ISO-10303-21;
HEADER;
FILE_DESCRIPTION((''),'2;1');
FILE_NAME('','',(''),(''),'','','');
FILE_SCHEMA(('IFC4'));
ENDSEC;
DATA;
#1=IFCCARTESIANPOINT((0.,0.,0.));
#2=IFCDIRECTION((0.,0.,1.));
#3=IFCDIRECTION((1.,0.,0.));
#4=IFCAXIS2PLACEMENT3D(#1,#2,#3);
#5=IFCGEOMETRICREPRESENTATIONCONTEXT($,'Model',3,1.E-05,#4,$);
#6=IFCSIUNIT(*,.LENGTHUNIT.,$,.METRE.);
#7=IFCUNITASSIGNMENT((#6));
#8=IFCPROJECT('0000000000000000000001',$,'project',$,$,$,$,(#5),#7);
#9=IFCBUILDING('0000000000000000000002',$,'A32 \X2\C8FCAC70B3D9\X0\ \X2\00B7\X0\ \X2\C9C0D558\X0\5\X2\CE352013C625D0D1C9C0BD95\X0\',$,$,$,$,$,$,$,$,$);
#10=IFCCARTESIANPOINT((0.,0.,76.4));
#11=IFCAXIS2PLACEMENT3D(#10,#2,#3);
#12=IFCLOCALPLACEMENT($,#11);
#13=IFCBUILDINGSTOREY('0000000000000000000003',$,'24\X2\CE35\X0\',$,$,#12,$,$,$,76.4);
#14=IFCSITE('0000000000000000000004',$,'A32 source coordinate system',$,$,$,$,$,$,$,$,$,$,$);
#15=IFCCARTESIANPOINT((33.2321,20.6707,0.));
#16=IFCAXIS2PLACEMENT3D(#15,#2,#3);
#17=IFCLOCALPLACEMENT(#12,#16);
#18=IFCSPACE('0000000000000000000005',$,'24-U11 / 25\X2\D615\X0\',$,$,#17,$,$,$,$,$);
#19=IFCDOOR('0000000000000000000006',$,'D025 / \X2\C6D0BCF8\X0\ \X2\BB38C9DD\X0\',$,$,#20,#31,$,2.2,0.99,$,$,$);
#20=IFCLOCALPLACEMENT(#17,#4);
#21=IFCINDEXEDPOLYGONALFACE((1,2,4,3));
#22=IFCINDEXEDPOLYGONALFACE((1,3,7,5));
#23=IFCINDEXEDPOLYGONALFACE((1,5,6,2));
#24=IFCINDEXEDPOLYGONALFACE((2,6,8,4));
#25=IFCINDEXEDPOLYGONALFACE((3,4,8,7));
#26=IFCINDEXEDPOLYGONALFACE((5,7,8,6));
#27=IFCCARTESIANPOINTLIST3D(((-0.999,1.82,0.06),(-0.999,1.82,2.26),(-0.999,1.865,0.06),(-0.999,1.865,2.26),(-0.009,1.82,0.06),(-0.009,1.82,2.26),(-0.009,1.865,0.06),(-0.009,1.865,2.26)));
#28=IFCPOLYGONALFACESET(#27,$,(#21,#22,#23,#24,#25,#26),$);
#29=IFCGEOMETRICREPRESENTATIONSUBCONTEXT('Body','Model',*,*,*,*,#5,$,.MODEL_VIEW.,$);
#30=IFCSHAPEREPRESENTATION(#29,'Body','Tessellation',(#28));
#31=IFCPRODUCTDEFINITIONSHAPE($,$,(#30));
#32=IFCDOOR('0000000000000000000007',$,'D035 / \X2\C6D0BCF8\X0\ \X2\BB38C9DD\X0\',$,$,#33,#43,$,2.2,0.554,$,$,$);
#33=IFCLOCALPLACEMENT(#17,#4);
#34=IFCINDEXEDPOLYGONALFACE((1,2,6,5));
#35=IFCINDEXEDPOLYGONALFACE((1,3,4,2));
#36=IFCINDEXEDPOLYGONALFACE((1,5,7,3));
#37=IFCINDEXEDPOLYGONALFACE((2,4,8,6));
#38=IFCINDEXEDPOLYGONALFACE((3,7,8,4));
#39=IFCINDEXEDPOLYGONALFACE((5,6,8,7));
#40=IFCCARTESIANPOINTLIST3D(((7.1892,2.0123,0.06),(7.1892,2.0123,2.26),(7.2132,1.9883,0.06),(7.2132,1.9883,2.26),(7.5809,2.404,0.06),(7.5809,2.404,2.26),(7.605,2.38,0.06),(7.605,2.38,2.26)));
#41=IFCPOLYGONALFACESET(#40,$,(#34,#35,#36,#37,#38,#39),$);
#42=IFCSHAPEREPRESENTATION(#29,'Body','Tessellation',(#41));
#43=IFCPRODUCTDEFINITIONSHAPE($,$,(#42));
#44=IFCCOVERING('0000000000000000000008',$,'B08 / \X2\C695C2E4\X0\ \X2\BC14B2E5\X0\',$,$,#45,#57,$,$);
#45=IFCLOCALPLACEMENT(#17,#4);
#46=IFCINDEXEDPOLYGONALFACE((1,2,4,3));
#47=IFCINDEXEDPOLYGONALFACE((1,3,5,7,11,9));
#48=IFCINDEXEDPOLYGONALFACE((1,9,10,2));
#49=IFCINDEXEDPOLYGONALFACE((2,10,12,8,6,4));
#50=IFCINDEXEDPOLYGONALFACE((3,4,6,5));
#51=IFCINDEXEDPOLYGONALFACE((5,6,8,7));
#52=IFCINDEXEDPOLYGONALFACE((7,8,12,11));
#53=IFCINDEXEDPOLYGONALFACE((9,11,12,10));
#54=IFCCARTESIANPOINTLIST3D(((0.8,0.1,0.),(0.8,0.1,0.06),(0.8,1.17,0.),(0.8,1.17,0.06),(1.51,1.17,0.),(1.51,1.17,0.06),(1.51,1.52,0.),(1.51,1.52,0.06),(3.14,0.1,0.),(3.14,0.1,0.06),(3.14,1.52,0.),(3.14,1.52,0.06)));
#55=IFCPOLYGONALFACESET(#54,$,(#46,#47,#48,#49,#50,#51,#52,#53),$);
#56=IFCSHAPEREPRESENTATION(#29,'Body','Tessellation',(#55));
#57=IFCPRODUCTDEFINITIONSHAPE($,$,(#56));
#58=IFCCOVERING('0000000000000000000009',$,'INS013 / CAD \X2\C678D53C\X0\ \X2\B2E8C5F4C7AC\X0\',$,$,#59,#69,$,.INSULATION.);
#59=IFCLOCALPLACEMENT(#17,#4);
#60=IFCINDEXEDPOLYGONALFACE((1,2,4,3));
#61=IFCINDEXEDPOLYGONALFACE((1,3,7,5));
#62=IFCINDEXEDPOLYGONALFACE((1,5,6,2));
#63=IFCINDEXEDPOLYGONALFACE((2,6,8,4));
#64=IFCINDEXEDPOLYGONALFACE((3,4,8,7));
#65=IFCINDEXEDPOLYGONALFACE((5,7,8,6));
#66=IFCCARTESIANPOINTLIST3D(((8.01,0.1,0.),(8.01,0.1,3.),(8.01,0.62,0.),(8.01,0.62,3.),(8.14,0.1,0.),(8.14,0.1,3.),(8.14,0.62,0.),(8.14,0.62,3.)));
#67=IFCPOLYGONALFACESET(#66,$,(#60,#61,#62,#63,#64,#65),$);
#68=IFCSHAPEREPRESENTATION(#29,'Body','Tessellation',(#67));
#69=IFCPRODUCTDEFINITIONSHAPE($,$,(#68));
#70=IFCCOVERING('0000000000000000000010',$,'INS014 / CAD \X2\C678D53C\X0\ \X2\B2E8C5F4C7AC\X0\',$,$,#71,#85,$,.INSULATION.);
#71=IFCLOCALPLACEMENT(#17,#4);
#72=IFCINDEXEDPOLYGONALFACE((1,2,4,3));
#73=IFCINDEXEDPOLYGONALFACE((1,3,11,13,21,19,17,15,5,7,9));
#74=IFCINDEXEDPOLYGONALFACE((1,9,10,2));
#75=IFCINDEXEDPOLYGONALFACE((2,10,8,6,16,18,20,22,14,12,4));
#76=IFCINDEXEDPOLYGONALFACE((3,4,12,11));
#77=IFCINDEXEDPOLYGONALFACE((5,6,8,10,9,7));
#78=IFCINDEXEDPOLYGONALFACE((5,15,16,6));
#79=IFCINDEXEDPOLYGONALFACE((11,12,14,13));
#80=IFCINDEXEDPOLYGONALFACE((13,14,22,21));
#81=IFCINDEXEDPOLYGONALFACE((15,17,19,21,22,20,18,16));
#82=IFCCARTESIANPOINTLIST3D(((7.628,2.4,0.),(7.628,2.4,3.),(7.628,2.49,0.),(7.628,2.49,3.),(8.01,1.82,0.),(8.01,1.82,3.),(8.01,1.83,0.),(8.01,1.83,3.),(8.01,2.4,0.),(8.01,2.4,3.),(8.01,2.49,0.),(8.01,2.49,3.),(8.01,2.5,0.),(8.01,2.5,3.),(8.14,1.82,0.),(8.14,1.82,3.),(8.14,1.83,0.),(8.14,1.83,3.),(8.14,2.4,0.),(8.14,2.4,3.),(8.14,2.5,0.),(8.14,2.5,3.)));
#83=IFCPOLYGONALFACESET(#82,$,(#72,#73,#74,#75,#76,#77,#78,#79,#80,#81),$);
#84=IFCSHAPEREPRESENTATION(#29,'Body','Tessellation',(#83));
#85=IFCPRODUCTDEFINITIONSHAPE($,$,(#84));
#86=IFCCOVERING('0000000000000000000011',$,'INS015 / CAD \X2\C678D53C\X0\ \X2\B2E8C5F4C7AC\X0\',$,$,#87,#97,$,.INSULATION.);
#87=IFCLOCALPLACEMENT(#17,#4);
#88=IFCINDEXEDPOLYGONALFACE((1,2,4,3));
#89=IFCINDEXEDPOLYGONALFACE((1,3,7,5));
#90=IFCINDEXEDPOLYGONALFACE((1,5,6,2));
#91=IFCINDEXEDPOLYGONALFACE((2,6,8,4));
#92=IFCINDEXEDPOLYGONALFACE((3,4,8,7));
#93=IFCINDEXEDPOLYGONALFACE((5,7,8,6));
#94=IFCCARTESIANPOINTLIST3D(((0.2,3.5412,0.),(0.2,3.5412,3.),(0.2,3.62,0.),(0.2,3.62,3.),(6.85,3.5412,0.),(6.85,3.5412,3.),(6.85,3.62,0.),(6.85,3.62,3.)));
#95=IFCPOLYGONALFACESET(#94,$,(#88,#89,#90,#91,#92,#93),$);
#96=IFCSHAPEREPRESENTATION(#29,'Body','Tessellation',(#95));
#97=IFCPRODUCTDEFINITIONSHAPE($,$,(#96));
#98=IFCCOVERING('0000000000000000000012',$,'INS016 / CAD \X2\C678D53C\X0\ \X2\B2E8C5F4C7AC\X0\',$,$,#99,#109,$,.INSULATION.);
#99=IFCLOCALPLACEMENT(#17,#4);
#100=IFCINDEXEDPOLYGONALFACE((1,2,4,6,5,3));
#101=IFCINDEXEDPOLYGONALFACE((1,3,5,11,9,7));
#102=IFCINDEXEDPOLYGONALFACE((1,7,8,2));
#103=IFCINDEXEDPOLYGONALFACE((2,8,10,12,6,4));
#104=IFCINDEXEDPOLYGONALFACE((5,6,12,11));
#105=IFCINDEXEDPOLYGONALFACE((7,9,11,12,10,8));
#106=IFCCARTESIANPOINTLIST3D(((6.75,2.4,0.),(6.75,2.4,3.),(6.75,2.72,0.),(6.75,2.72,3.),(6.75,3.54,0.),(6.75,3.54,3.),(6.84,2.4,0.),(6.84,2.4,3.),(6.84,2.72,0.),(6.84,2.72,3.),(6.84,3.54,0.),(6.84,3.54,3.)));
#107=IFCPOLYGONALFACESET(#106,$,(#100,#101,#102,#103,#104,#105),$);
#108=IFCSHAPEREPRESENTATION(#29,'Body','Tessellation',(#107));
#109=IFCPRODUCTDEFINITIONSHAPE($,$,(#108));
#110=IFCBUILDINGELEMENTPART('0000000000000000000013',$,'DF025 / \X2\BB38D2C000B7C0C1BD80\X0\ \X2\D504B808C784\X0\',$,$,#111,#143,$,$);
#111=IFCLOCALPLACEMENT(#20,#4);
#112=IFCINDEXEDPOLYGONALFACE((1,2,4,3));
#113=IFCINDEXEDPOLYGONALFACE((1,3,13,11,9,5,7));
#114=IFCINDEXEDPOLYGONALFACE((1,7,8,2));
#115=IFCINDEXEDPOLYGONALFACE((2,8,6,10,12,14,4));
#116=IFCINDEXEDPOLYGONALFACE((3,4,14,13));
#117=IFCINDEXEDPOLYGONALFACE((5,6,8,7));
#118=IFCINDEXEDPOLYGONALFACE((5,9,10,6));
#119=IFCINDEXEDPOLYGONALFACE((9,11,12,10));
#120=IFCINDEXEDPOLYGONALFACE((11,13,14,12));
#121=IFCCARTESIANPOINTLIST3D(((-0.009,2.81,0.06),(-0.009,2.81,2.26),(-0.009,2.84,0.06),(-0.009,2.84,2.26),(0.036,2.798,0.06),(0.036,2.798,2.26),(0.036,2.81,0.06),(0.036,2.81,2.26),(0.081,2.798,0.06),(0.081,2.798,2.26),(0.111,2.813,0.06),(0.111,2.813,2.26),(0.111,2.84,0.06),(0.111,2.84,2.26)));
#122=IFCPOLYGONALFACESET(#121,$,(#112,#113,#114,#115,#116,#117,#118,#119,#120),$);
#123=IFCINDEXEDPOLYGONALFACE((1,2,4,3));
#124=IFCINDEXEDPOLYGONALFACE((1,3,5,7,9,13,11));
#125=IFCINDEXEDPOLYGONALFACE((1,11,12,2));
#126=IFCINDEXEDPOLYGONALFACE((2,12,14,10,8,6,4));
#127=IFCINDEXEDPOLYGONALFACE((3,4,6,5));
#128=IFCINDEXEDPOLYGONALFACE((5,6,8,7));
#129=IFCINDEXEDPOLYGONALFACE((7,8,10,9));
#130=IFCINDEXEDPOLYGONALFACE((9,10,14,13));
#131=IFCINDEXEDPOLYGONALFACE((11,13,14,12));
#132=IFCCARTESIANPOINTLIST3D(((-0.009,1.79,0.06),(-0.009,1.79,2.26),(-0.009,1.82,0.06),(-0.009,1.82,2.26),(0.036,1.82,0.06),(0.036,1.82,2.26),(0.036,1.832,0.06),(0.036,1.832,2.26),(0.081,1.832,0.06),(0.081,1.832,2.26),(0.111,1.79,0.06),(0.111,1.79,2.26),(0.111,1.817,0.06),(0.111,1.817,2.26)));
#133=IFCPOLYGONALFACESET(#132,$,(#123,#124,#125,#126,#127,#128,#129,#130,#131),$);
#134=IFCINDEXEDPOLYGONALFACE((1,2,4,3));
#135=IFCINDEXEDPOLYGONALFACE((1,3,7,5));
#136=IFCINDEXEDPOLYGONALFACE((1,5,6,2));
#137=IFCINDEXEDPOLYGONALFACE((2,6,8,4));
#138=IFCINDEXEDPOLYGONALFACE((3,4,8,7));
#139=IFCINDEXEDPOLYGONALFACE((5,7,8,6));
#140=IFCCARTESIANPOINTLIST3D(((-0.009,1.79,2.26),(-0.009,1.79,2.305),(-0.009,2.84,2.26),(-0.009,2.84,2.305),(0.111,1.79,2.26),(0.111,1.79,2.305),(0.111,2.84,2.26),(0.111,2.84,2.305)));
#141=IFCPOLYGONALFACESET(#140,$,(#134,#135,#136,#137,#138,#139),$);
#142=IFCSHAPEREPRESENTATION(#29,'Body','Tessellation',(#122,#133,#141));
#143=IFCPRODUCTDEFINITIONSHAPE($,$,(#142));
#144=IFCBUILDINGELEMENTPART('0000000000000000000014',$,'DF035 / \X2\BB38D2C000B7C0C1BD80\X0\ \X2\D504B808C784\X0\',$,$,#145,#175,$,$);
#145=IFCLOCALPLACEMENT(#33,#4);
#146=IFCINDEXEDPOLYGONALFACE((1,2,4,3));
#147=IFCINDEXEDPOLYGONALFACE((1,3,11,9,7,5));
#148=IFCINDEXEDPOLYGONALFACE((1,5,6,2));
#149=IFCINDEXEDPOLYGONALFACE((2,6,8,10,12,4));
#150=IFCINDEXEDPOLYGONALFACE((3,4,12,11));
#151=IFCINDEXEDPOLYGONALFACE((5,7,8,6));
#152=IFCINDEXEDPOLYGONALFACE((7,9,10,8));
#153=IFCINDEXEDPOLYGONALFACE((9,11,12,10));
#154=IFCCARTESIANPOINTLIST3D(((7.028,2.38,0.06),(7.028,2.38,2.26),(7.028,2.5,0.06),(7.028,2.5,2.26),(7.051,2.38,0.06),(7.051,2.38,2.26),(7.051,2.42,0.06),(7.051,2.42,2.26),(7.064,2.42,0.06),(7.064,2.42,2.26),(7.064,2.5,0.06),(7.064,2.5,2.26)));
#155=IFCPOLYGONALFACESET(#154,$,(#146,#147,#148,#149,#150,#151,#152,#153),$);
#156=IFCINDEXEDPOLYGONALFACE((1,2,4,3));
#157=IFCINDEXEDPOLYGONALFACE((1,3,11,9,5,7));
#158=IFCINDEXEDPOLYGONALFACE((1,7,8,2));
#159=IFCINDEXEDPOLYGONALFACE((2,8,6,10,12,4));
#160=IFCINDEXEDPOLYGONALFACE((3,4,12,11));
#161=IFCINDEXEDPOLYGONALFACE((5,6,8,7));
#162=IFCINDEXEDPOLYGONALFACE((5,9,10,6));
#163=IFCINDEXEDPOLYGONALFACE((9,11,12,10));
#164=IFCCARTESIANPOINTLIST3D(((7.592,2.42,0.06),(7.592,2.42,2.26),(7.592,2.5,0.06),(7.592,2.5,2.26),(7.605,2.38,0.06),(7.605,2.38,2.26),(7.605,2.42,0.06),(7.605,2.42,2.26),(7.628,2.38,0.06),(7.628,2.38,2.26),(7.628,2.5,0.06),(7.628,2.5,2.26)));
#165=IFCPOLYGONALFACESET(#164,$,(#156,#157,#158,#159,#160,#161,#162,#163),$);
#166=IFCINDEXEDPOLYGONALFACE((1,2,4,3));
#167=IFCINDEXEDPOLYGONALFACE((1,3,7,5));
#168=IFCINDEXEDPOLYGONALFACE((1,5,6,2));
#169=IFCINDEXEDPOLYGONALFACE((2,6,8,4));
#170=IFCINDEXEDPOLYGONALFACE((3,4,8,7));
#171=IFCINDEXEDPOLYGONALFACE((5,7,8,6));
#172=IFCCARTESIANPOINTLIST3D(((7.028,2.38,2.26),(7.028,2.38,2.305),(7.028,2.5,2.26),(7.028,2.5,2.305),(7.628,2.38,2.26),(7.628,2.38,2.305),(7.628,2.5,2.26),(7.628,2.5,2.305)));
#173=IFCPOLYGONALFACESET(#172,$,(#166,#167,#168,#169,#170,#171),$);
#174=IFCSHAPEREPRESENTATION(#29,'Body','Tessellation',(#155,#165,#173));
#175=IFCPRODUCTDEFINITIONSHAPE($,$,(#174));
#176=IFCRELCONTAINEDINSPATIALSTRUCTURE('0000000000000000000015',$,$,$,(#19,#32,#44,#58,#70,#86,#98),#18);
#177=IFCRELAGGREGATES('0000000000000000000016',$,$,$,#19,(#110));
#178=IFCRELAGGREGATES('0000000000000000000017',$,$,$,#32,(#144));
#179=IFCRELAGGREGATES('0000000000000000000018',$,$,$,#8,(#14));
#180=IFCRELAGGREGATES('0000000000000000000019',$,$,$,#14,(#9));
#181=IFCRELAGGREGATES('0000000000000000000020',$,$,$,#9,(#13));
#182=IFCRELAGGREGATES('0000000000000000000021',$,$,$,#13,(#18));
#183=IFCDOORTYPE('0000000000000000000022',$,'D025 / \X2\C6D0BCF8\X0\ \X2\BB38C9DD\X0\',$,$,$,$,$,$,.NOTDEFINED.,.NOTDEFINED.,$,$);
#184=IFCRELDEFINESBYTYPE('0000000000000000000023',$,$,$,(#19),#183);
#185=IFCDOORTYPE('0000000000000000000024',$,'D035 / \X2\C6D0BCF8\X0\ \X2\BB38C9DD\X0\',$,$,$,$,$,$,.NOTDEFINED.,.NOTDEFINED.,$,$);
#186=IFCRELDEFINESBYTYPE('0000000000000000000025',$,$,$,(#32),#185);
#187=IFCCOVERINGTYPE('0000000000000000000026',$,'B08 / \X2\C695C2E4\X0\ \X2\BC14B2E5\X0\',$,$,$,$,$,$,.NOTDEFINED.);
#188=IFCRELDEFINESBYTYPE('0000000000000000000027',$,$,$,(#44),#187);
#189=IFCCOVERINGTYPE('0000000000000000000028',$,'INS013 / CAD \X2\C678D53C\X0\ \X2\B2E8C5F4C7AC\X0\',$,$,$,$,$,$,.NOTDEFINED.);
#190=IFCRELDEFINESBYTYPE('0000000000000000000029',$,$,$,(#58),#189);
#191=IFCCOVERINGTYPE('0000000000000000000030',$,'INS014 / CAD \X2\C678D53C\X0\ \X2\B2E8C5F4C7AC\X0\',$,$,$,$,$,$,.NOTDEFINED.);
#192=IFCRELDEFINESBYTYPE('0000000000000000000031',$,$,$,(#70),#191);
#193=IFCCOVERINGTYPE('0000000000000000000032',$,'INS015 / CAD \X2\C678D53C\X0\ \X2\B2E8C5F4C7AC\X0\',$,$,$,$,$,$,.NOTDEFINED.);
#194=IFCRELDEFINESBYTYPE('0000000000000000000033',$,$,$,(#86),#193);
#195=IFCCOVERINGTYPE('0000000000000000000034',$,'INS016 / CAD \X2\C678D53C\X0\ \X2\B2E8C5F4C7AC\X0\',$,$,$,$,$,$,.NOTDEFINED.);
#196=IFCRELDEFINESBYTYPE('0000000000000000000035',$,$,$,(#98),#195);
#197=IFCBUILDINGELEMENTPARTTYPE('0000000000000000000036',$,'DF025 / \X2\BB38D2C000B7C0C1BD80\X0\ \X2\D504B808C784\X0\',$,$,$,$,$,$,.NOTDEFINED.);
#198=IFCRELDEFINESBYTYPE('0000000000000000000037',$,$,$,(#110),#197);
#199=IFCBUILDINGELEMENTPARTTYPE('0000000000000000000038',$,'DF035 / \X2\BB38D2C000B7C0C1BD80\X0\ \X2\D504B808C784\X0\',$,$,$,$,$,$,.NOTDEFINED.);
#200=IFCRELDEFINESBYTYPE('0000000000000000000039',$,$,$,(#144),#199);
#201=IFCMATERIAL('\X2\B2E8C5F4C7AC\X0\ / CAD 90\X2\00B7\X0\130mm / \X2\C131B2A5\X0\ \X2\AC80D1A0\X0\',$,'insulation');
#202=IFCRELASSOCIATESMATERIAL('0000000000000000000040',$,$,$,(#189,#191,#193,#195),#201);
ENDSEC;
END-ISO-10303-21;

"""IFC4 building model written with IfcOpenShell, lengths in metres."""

from ifc_helpers import new_model, si_unit, frame, origin, origin_with_axes, place, context, subcontext, project, spatial, polyline, outline, extrude, source, transform, mapped, material, type_object, type_shapes, element, aggregate, save


model = new_model("IFC4")

# Units and contexts
model_context = context("Model", 3, precision=1e-05, world=origin_with_axes())
body_context = subcontext(model_context, "Body", "Model", "MODEL_VIEW")
ifc_project = project(units=[si_unit("LENGTHUNIT", "METRE")], contexts=[model_context])

# Site, building, storey, space
storey_placement = place(None, frame((0.0, 0.0, 76.4), z_axis=(0.0, 0.0, 1.0), x_axis=(1.0, 0.0, 0.0)))
space_1_placement = place(storey_placement, frame((33.2321, 20.6707, 0.0), z_axis=(0.0, 0.0, 1.0), x_axis=(1.0, 0.0, 0.0)))
site = spatial("IfcSite", under=ifc_project, Name="A32 source coordinate system")
building = spatial("IfcBuilding", under=site, Name="A32 주거동 · 지하5층–옥탑지붕")
storey = spatial("IfcBuildingStorey", under=building, at=storey_placement, Name="24층", Elevation=76.4)
space_1 = spatial("IfcSpace", under=storey, at=space_1_placement, Name="24-U11 / 25형")

# Doors
door_type_1 = type_object("IfcDoorType", Name="D025 / 원본 문짝", OperationType="NOTDEFINED", PredefinedType="NOTDEFINED")
shared_shape_1 = source(origin(), body_context, "Body", "SweptSolid", [
    extrude(outline(polyline([(-0.009, 1.82), (-0.999, 1.82), (-0.999, 1.865), (-0.009, 1.865), (-0.009, 1.82)])), frame((0.0, 0.0, 0.06)), (0.0, 0.0, 1.0), 2.2),
])
type_shapes(door_type_1, [shared_shape_1])
door_1_placement = place(space_1_placement, origin_with_axes())
door_1 = element("IfcDoor", 1, at=door_1_placement, inside=space_1, type_object=door_type_1, Name="D025 / 원본 문짝", OverallHeight=2.2, OverallWidth=0.99, context=body_context, shape_type="MappedRepresentation", body=[
    mapped(shared_shape_1, transform((0.0, 0.0, 0.0), scale=1.0)),
])
door_type_2 = type_object("IfcDoorType", Name="D035 / 원본 문짝", OperationType="NOTDEFINED", PredefinedType="NOTDEFINED")
shared_shape_2 = source(origin(), body_context, "Body", "SweptSolid", [
    extrude(outline(polyline([(7.605, 2.38), (7.2132, 1.9883), (7.1892, 2.0123), (7.5809, 2.404), (7.605, 2.38)])), frame((0.0, 0.0, 0.06)), (0.0, 0.0, 1.0), 2.2),
])
type_shapes(door_type_2, [shared_shape_2])
door_2_placement = place(space_1_placement, origin_with_axes())
door_2 = element("IfcDoor", 2, at=door_2_placement, inside=space_1, type_object=door_type_2, Name="D035 / 원본 문짝", OverallHeight=2.2, OverallWidth=0.554, context=body_context, shape_type="MappedRepresentation", body=[
    mapped(shared_shape_2, transform((0.0, 0.0, 0.0), scale=1.0)),
])

# Coverings
covering_type_1 = type_object("IfcCoveringType", Name="B08 / 욕실 바닥", PredefinedType="NOTDEFINED")
shared_shape_3 = source(origin(), body_context, "Body", "SweptSolid", [
    extrude(outline(polyline([(3.14, 0.1), (0.8, 0.1), (0.8, 1.17), (1.51, 1.17), (1.51, 1.52), (3.14, 1.52), (3.14, 0.1)])), origin(), (0.0, 0.0, 1.0), 0.06),
])
type_shapes(covering_type_1, [shared_shape_3])
covering_1_placement = place(space_1_placement, origin_with_axes())
element("IfcCovering", 3, at=covering_1_placement, inside=space_1, type_object=covering_type_1, Name="B08 / 욕실 바닥", context=body_context, shape_type="MappedRepresentation", body=[
    mapped(shared_shape_3, transform((0.0, 0.0, 0.0), scale=1.0)),
])
ifc_material = material(Name="단열재 / CAD 90·130mm / 성능 검토", Category="insulation")
covering_type_2 = type_object("IfcCoveringType", Name="INS013 / CAD 외피 단열재", PredefinedType="NOTDEFINED", material=ifc_material)
shared_shape_4 = source(origin(), body_context, "Body", "SweptSolid", [
    extrude(outline(polyline([(8.14, 0.1), (8.01, 0.1), (8.01, 0.62), (8.14, 0.62), (8.14, 0.1)])), origin(), (0.0, 0.0, 1.0), 3.0),
])
type_shapes(covering_type_2, [shared_shape_4])
covering_2_placement = place(space_1_placement, origin_with_axes())
element("IfcCovering", 4, at=covering_2_placement, inside=space_1, type_object=covering_type_2, Name="INS013 / CAD 외피 단열재", PredefinedType="INSULATION", context=body_context, shape_type="MappedRepresentation", body=[
    mapped(shared_shape_4, transform((0.0, 0.0, 0.0), scale=1.0)),
])
covering_type_3 = type_object("IfcCoveringType", Name="INS014 / CAD 외피 단열재", PredefinedType="NOTDEFINED", material=ifc_material)
shared_shape_5 = source(origin(), body_context, "Body", "SweptSolid", [
    extrude(outline(polyline([(8.14, 2.5), (8.14, 2.4), (8.14, 1.83), (8.14, 1.82), (8.01, 1.82), (8.01, 1.83), (8.01, 2.4), (7.628, 2.4), (7.628, 2.49), (8.01, 2.49), (8.01, 2.5), (8.14, 2.5)])), origin(), (0.0, 0.0, 1.0), 3.0),
])
type_shapes(covering_type_3, [shared_shape_5])
covering_3_placement = place(space_1_placement, origin_with_axes())
element("IfcCovering", 5, at=covering_3_placement, inside=space_1, type_object=covering_type_3, Name="INS014 / CAD 외피 단열재", PredefinedType="INSULATION", context=body_context, shape_type="MappedRepresentation", body=[
    mapped(shared_shape_5, transform((0.0, 0.0, 0.0), scale=1.0)),
])
covering_type_4 = type_object("IfcCoveringType", Name="INS015 / CAD 외피 단열재", PredefinedType="NOTDEFINED", material=ifc_material)
shared_shape_6 = source(origin(), body_context, "Body", "SweptSolid", [
    extrude(outline(polyline([(0.2, 3.5412), (0.2, 3.62), (6.85, 3.62), (6.85, 3.5412), (0.2, 3.5412)])), origin(), (0.0, 0.0, 1.0), 3.0),
])
type_shapes(covering_type_4, [shared_shape_6])
covering_4_placement = place(space_1_placement, origin_with_axes())
element("IfcCovering", 6, at=covering_4_placement, inside=space_1, type_object=covering_type_4, Name="INS015 / CAD 외피 단열재", PredefinedType="INSULATION", context=body_context, shape_type="MappedRepresentation", body=[
    mapped(shared_shape_6, transform((0.0, 0.0, 0.0), scale=1.0)),
])
covering_type_5 = type_object("IfcCoveringType", Name="INS016 / CAD 외피 단열재", PredefinedType="NOTDEFINED", material=ifc_material)
shared_shape_7 = source(origin(), body_context, "Body", "SweptSolid", [
    extrude(outline(polyline([(6.84, 2.72), (6.84, 2.4), (6.75, 2.4), (6.75, 2.72), (6.75, 3.54), (6.84, 3.54), (6.84, 2.72)])), origin(), (0.0, 0.0, 1.0), 3.0),
])
type_shapes(covering_type_5, [shared_shape_7])
covering_5_placement = place(space_1_placement, origin_with_axes())
element("IfcCovering", 7, at=covering_5_placement, inside=space_1, type_object=covering_type_5, Name="INS016 / CAD 외피 단열재", PredefinedType="INSULATION", context=body_context, shape_type="MappedRepresentation", body=[
    mapped(shared_shape_7, transform((0.0, 0.0, 0.0), scale=1.0)),
])

# Building element parts
building_element_part_type_1 = type_object("IfcBuildingElementPartType", Name="DF025 / 문틀·상부 프레임", PredefinedType="NOTDEFINED")
shared_shape_8 = source(origin(), body_context, "Body", "SweptSolid", [
    extrude(outline(polyline([(0.111, 2.84), (0.111, 2.813), (0.081, 2.798), (0.036, 2.798), (0.036, 2.81), (-0.009, 2.81), (-0.009, 2.84), (0.111, 2.84)])), frame((0.0, 0.0, 0.06)), (0.0, 0.0, 1.0), 2.2),
    extrude(outline(polyline([(-0.009, 1.82), (0.036, 1.82), (0.036, 1.832), (0.081, 1.832), (0.111, 1.817), (0.111, 1.79), (-0.009, 1.79), (-0.009, 1.82)])), frame((0.0, 0.0, 0.06)), (0.0, 0.0, 1.0), 2.2),
    extrude(outline(polyline([(-0.009, 1.79), (-0.009, 2.84), (0.111, 2.84), (0.111, 1.79), (-0.009, 1.79)])), frame((0.0, 0.0, 2.26)), (0.0, 0.0, 1.0), 0.045),
])
type_shapes(building_element_part_type_1, [shared_shape_8])
building_element_part_1_placement = place(door_1_placement, origin_with_axes())
building_element_part_1 = element("IfcBuildingElementPart", 8, at=building_element_part_1_placement, type_object=building_element_part_type_1, Name="DF025 / 문틀·상부 프레임", context=body_context, shape_type="MappedRepresentation", body=[
    mapped(shared_shape_8, transform((0.0, 0.0, 0.0), scale=1.0)),
])
aggregate(door_1, [building_element_part_1])
building_element_part_type_2 = type_object("IfcBuildingElementPartType", Name="DF035 / 문틀·상부 프레임", PredefinedType="NOTDEFINED")
shared_shape_9 = source(origin(), body_context, "Body", "SweptSolid", [
    extrude(outline(polyline([(7.064, 2.5), (7.064, 2.42), (7.051, 2.42), (7.051, 2.38), (7.028, 2.38), (7.028, 2.5), (7.064, 2.5)])), frame((0.0, 0.0, 0.06)), (0.0, 0.0, 1.0), 2.2),
    extrude(outline(polyline([(7.628, 2.38), (7.605, 2.38), (7.605, 2.42), (7.592, 2.42), (7.592, 2.5), (7.628, 2.5), (7.628, 2.38)])), frame((0.0, 0.0, 0.06)), (0.0, 0.0, 1.0), 2.2),
    extrude(outline(polyline([(7.028, 2.38), (7.028, 2.5), (7.628, 2.5), (7.628, 2.38), (7.028, 2.38)])), frame((0.0, 0.0, 2.26)), (0.0, 0.0, 1.0), 0.045),
])
type_shapes(building_element_part_type_2, [shared_shape_9])
building_element_part_2_placement = place(door_2_placement, origin_with_axes())
building_element_part_2 = element("IfcBuildingElementPart", 9, at=building_element_part_2_placement, type_object=building_element_part_type_2, Name="DF035 / 문틀·상부 프레임", context=body_context, shape_type="MappedRepresentation", body=[
    mapped(shared_shape_9, transform((0.0, 0.0, 0.0), scale=1.0)),
])
aggregate(door_2, [building_element_part_2])

save(model, "model.ifc")
